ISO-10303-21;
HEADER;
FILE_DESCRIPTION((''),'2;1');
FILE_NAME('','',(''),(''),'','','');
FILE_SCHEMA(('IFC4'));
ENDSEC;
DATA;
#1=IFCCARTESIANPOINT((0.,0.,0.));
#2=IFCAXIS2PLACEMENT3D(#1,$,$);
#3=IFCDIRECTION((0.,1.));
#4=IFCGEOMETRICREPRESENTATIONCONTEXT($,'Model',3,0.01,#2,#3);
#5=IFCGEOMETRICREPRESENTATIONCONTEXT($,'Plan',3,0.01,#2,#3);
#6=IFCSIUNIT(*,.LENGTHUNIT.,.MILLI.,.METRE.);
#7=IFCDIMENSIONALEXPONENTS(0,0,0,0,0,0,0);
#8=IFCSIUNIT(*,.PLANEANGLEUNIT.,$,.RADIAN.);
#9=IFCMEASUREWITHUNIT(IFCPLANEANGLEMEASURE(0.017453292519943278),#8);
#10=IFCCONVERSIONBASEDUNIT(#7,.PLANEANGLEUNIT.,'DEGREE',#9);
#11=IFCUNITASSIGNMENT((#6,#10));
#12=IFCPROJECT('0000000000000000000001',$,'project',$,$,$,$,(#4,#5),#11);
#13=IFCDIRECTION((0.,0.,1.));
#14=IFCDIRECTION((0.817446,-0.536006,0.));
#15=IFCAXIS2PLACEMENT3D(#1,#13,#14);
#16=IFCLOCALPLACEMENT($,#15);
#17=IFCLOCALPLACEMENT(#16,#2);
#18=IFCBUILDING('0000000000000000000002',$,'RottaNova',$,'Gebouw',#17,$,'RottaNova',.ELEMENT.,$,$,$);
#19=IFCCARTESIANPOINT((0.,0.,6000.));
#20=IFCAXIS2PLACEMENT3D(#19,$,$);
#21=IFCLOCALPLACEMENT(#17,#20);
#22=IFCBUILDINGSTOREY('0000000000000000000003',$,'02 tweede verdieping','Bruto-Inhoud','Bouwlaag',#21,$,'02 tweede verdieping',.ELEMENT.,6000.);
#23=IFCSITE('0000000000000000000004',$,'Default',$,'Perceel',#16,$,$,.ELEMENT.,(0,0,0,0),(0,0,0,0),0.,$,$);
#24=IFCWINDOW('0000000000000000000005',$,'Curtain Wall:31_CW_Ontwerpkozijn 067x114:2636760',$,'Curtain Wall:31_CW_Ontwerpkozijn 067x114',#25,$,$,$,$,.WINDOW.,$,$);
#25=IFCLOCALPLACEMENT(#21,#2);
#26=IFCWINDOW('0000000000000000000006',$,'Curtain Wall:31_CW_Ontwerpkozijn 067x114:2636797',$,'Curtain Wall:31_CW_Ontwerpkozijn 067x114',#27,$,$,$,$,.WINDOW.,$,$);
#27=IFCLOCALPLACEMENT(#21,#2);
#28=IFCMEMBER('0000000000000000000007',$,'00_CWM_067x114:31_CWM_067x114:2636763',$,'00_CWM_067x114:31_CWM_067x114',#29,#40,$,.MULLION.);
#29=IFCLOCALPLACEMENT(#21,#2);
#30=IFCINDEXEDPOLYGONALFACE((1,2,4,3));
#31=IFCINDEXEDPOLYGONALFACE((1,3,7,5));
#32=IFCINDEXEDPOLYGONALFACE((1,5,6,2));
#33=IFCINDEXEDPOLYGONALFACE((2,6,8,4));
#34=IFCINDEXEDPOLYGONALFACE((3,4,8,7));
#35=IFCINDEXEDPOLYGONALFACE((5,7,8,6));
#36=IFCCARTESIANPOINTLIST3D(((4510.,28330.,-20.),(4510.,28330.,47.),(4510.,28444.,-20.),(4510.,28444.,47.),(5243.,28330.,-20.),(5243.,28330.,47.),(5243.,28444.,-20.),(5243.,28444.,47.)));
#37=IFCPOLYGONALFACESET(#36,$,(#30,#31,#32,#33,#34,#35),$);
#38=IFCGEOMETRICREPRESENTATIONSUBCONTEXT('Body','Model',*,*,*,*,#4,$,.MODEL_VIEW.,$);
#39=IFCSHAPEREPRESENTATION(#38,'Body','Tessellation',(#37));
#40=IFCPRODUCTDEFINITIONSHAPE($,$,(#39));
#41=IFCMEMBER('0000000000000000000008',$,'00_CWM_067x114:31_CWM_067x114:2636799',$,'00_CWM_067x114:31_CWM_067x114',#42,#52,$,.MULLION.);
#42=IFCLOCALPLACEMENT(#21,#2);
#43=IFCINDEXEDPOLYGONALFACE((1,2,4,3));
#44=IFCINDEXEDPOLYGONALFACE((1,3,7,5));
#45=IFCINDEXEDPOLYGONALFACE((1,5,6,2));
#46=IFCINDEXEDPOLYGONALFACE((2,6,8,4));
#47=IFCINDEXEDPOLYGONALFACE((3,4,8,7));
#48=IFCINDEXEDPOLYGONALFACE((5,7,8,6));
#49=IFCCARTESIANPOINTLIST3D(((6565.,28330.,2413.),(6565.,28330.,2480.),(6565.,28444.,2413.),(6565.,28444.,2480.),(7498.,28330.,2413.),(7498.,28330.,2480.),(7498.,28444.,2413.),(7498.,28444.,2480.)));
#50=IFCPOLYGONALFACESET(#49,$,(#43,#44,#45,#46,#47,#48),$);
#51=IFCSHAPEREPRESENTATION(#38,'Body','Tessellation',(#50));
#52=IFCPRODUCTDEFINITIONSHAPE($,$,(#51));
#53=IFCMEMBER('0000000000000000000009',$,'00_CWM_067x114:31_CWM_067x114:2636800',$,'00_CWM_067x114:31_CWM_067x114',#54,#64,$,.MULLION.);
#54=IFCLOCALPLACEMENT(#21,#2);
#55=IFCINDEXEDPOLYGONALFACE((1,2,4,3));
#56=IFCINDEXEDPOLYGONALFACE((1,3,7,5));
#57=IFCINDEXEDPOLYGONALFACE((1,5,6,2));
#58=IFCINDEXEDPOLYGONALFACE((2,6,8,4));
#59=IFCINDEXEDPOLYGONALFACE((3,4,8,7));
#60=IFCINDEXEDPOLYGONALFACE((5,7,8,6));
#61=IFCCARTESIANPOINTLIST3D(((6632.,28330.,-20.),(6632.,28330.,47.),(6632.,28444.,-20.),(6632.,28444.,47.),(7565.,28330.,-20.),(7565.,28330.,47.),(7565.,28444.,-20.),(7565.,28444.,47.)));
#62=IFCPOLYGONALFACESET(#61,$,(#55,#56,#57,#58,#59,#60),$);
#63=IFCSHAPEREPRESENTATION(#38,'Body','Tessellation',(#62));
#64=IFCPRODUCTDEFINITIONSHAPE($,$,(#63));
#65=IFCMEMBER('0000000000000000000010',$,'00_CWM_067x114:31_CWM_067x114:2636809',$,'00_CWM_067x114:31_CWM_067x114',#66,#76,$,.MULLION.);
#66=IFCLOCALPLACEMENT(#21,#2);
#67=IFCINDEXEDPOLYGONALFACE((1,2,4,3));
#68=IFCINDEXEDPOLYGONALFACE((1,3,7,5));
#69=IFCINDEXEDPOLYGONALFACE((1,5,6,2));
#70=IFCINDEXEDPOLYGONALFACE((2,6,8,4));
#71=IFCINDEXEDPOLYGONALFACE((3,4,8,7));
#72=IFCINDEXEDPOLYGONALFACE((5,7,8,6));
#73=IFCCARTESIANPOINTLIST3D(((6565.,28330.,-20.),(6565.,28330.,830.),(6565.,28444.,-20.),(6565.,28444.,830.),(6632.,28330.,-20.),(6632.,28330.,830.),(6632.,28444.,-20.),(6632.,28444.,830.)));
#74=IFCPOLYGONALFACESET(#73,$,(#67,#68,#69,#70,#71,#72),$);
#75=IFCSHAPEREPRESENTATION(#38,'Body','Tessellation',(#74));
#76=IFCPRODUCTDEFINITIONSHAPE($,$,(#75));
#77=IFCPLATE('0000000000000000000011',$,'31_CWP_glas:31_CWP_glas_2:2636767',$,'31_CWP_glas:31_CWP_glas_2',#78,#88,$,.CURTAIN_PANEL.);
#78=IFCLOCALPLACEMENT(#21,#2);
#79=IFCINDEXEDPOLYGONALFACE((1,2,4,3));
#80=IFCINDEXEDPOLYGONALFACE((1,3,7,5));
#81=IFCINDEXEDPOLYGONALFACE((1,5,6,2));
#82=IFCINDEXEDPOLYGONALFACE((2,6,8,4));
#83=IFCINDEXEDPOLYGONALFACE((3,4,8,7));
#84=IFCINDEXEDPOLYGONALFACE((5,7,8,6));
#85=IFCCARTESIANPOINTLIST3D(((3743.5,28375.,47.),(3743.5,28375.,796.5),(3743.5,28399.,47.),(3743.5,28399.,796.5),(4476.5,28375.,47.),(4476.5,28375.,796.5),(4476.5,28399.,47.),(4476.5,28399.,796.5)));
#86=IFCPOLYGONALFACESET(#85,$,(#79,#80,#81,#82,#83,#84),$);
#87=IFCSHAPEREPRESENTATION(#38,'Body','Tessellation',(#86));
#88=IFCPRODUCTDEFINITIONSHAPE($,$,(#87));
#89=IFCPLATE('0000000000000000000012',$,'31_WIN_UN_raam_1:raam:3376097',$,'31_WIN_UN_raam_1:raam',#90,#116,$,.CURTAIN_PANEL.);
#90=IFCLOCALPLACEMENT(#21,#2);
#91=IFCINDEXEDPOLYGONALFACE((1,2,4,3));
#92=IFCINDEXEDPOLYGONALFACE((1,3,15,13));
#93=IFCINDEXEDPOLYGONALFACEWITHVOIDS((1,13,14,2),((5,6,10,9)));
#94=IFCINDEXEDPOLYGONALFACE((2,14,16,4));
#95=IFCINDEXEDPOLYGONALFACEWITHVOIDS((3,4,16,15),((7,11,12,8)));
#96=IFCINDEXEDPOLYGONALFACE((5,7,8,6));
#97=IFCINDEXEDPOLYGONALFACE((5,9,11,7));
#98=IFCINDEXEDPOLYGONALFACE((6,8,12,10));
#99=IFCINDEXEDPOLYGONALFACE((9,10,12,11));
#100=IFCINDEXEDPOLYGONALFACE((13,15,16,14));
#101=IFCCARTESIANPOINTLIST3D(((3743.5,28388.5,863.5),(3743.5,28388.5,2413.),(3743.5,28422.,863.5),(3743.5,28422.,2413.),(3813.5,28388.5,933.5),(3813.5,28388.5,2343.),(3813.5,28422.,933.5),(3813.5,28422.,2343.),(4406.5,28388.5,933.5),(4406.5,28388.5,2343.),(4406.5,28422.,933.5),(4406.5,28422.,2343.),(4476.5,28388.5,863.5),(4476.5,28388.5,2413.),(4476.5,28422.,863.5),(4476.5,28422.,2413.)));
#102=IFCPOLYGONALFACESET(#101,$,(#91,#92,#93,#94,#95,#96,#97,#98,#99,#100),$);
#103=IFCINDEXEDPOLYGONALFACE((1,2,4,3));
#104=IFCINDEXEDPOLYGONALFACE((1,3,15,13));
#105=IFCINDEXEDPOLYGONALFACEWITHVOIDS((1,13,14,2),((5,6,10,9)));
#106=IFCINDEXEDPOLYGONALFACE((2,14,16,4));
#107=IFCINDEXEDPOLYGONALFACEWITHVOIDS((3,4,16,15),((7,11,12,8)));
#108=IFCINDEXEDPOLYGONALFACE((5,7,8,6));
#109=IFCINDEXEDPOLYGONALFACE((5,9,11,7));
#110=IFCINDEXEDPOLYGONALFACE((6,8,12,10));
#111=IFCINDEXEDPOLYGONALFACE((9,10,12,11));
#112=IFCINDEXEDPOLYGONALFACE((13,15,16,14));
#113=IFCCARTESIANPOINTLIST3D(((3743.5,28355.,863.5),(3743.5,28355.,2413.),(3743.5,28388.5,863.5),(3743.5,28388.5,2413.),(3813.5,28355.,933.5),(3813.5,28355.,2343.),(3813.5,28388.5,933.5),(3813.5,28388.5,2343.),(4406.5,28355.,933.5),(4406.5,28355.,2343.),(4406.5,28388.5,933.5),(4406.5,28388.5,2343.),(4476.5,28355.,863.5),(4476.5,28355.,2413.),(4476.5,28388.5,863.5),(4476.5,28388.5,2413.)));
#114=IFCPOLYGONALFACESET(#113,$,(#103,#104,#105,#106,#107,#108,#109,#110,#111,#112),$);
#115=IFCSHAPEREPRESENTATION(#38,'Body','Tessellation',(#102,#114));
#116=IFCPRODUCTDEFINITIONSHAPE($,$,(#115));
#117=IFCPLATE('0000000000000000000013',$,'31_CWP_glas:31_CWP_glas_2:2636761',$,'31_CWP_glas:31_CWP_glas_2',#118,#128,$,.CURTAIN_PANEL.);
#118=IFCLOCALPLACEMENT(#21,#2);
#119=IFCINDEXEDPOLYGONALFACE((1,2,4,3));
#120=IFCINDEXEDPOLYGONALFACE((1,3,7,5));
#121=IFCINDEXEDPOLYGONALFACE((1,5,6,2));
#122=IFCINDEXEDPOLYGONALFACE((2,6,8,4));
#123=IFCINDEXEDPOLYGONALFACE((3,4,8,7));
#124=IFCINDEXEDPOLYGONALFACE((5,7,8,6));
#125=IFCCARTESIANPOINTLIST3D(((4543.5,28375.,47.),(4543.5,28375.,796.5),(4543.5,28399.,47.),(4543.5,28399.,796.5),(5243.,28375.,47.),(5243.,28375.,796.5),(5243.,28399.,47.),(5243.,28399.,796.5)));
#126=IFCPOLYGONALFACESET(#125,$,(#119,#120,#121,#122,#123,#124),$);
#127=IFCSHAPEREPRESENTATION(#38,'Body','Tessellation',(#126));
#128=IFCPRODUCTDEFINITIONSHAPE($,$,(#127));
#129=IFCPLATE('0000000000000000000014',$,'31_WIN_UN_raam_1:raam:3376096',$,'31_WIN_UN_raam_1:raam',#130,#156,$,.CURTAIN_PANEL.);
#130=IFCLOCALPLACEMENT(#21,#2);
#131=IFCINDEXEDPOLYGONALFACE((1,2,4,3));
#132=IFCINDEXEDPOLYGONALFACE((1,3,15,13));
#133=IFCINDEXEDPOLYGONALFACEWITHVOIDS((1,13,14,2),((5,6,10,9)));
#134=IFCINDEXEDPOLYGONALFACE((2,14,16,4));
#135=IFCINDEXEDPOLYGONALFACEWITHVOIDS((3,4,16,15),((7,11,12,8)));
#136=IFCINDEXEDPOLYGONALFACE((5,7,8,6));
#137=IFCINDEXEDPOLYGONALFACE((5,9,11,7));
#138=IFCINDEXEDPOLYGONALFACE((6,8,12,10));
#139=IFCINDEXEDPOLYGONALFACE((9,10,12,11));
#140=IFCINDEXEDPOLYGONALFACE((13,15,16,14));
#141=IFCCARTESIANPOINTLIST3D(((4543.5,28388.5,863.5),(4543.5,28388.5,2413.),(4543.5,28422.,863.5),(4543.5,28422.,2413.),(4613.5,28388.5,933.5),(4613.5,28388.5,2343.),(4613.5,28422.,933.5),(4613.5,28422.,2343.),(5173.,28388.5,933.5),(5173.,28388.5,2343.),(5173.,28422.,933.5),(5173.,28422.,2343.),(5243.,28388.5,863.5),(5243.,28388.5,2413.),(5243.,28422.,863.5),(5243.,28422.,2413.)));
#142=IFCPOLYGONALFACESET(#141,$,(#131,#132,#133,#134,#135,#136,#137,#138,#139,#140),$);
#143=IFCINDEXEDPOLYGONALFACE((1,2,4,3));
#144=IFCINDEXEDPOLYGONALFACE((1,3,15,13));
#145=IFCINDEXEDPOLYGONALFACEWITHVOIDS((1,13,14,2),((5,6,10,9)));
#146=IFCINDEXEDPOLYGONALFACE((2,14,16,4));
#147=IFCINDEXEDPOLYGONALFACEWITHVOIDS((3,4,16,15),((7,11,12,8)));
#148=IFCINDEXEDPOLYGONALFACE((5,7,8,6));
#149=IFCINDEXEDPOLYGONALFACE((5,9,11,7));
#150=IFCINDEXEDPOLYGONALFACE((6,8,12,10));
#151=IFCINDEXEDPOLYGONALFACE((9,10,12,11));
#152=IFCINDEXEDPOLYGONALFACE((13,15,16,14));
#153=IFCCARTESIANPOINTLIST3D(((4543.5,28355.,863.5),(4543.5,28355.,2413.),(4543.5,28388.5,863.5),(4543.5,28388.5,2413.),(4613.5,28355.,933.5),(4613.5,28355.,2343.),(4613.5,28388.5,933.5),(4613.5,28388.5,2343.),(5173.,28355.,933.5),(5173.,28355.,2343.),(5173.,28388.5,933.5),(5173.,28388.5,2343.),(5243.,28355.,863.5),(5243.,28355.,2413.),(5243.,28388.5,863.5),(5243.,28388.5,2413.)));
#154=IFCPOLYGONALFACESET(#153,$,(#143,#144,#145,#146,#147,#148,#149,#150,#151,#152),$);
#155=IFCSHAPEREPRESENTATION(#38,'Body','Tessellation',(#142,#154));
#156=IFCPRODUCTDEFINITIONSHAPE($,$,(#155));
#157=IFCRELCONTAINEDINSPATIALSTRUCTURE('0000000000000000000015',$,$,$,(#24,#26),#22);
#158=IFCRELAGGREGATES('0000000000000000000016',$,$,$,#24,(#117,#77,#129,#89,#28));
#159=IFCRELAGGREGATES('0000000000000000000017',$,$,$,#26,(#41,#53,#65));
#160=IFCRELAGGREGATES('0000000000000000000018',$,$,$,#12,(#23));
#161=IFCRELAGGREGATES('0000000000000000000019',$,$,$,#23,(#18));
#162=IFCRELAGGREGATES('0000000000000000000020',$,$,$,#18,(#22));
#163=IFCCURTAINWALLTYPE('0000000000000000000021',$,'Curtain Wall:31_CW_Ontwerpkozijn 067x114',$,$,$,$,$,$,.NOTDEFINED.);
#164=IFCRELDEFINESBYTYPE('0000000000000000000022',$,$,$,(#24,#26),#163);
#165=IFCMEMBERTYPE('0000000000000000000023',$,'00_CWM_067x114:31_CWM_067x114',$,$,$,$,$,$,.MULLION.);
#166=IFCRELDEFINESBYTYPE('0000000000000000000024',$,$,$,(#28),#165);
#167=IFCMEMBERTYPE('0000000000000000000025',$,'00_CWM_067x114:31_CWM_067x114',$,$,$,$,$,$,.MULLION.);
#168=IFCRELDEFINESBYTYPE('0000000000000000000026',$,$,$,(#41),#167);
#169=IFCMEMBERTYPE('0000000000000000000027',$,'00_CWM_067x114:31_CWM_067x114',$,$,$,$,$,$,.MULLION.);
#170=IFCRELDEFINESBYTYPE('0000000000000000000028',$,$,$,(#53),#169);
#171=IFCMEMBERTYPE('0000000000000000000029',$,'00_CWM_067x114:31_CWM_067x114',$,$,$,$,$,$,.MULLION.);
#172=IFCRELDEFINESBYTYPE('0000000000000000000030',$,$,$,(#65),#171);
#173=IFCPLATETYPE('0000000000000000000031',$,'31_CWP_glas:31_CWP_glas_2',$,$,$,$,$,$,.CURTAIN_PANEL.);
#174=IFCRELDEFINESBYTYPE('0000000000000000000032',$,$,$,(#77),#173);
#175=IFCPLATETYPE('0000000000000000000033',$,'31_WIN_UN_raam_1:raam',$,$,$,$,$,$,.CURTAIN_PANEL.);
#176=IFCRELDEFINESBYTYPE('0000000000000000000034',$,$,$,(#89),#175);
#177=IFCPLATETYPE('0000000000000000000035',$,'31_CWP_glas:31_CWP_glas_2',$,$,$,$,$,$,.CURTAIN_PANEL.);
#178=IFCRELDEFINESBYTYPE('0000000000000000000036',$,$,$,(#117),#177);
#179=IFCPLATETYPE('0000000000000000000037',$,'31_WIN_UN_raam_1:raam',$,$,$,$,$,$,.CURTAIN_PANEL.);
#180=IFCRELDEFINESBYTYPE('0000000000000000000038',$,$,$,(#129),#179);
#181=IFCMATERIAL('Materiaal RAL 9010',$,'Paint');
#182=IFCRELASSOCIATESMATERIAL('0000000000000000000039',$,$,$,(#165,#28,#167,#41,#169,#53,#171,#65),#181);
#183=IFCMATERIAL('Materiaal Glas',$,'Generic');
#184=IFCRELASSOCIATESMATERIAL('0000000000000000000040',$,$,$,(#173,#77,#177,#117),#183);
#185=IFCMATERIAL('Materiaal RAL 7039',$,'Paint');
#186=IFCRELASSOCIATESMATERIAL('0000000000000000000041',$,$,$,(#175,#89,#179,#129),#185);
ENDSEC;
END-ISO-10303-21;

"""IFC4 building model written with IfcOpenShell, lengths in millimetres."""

from ifc_helpers import new_model, entity, si_unit, converted_unit, direction, frame, origin, place, context, subcontext, project, spatial, indexed_curve, outline, extrude, source, transform, mapped, material, type_object, type_shapes, element, aggregate, save


model = new_model("IFC4")

# Units and contexts
model_context = context("Model", 3, precision=0.01, world=origin(), true_north=direction((0.0, 1.0)))
plan_context = context("Plan", 3, precision=0.01, world=origin(), true_north=direction((0.0, 1.0)))
body_context = subcontext(model_context, "Body", "Model", "MODEL_VIEW")
ifc_project = project(units=[si_unit("LENGTHUNIT", "METRE", prefix="MILLI"), converted_unit("PLANEANGLEUNIT", "DEGREE", entity("IfcPlaneAngleMeasure", 0.017453292519943278), si_unit("PLANEANGLEUNIT", "RADIAN"), dimensions=[0, 0, 0, 0, 0, 0, 0])], contexts=[model_context, plan_context])

# Site, building, storey
site_placement = place(None, frame((0.0, 0.0, 0.0), z_axis=(0.0, 0.0, 1.0), x_axis=(0.817446, -0.536006, 0.0)))
site = spatial("IfcSite", under=ifc_project, at=site_placement, Name="Default", ObjectType="Perceel", CompositionType="ELEMENT", RefLatitude=(0, 0, 0, 0), RefLongitude=(0, 0, 0, 0), RefElevation=0.0)
building_placement = place(site_placement, origin())
building = spatial("IfcBuilding", under=site, at=building_placement, Name="RottaNova", ObjectType="Gebouw", LongName="RottaNova", CompositionType="ELEMENT")
storey_placement = place(building_placement, frame((0.0, 0.0, 6000.0)))
storey = spatial("IfcBuildingStorey", under=building, at=storey_placement, Name="02 tweede verdieping", Description="Bruto-Inhoud", ObjectType="Bouwlaag", LongName="02 tweede verdieping", CompositionType="ELEMENT", Elevation=6000.0)

# Windows
curtain_wall_type = type_object("IfcCurtainWallType", Name="Curtain Wall:31_CW_Ontwerpkozijn 067x114", PredefinedType="NOTDEFINED")
window_1_placement = place(storey_placement, frame((0.0, 0.0, -6000.0)))
window_1 = element("IfcWindow", 1, at=window_1_placement, inside=storey, type_object=curtain_wall_type, Name="Curtain Wall:31_CW_Ontwerpkozijn 067x114:2636760", ObjectType="Curtain Wall:31_CW_Ontwerpkozijn 067x114", PredefinedType="WINDOW")
ifc_material_1 = material(Name="Materiaal RAL 9010", Category="Paint")
window_2_placement = place(storey_placement, frame((0.0, 0.0, -6000.0)))
window_2 = element("IfcWindow", 2, at=window_2_placement, inside=storey, type_object=curtain_wall_type, Name="Curtain Wall:31_CW_Ontwerpkozijn 067x114:2636797", ObjectType="Curtain Wall:31_CW_Ontwerpkozijn 067x114", PredefinedType="WINDOW")

# Members
member_type_1 = type_object("IfcMemberType", Name="00_CWM_067x114:31_CWM_067x114", PredefinedType="MULLION", material=ifc_material_1)
shared_shape_1 = source(origin(), body_context, "Body", "SweptSolid", [
    extrude(outline(indexed_curve([(-33.5, -57.0), (33.5, -57.0), (33.5, 57.0), (-33.5, 57.0), (-33.5, -57.0)], self_intersect=False)), frame((-33.5, 57.0, -733.0), z_axis=(0.0, 0.0, 1.0), x_axis=(-1.0, 0.0, 0.0)), (0.0, 0.0, 1.0), 733.0),
])
type_shapes(member_type_1, [shared_shape_1])
member_1_placement = place(window_1_placement, frame((5243.0, 28330.0, 5980.0), z_axis=(1.0, 0.0, 0.0), x_axis=(0.0, 0.0, -1.0)))
member_1 = element("IfcMember", 3, at=member_1_placement, type_object=member_type_1, material=ifc_material_1, Name="00_CWM_067x114:31_CWM_067x114:2636763", ObjectType="00_CWM_067x114:31_CWM_067x114", PredefinedType="MULLION", context=body_context, shape_type="MappedRepresentation", body=[
    mapped(shared_shape_1, transform((0.0, 0.0, 0.0), scale=1.0)),
])
member_type_2 = type_object("IfcMemberType", Name="00_CWM_067x114:31_CWM_067x114", PredefinedType="MULLION", material=ifc_material_1)
shared_shape_2 = source(origin(), body_context, "Body", "SweptSolid", [
    extrude(outline(indexed_curve([(-33.5, -57.0), (33.5, -57.0), (33.5, 57.0), (-33.5, 57.0), (-33.5, -57.0)], self_intersect=False)), frame((-33.5, -57.0, -933.0), z_axis=(0.0, 0.0, 1.0), x_axis=(-1.0, 0.0, 0.0)), (0.0, 0.0, 1.0), 933.0),
])
type_shapes(member_type_2, [shared_shape_2])
member_2_placement = place(window_2_placement, frame((7498.0, 28330.0, 8480.0), z_axis=(1.0, 0.0, 0.0), x_axis=(0.0, 0.0, 1.0)))
member_2 = element("IfcMember", 4, at=member_2_placement, type_object=member_type_2, material=ifc_material_1, Name="00_CWM_067x114:31_CWM_067x114:2636799", ObjectType="00_CWM_067x114:31_CWM_067x114", PredefinedType="MULLION", context=body_context, shape_type="MappedRepresentation", body=[
    mapped(shared_shape_2, transform((0.0, 0.0, 0.0), scale=1.0)),
])
member_type_3 = type_object("IfcMemberType", Name="00_CWM_067x114:31_CWM_067x114", PredefinedType="MULLION", material=ifc_material_1)
shared_shape_3 = source(origin(), body_context, "Body", "SweptSolid", [
    extrude(outline(indexed_curve([(-33.5, -57.0), (33.5, -57.0), (33.5, 57.0), (-33.5, 57.0), (-33.5, -57.0)], self_intersect=False)), frame((-33.5, -57.0, -933.0), z_axis=(0.0, 0.0, 1.0), x_axis=(-1.0, 0.0, 0.0)), (0.0, 0.0, 1.0), 933.0),
])
type_shapes(member_type_3, [shared_shape_3])
member_3_placement = place(window_2_placement, frame((6632.0, 28330.0, 5980.0), z_axis=(-1.0, 0.0, 0.0), x_axis=(0.0, 0.0, -1.0)))
member_3 = element("IfcMember", 5, at=member_3_placement, type_object=member_type_3, material=ifc_material_1, Name="00_CWM_067x114:31_CWM_067x114:2636800", ObjectType="00_CWM_067x114:31_CWM_067x114", PredefinedType="MULLION", context=body_context, shape_type="MappedRepresentation", body=[
    mapped(shared_shape_3, transform((0.0, 0.0, 0.0), scale=1.0)),
])
member_type_4 = type_object("IfcMemberType", Name="00_CWM_067x114:31_CWM_067x114", PredefinedType="MULLION", material=ifc_material_1)
shared_shape_4 = source(origin(), body_context, "Body", "SweptSolid", [
    extrude(outline(indexed_curve([(-33.5, -57.0), (33.5, -57.0), (33.5, 57.0), (-33.5, 57.0), (-33.5, -57.0)], self_intersect=False)), frame((-33.5, -57.0, -850.0), z_axis=(0.0, 0.0, 1.0), x_axis=(-1.0, 0.0, 0.0)), (0.0, 0.0, 1.0), 850.0),
])
type_shapes(member_type_4, [shared_shape_4])
member_4_placement = place(window_2_placement, frame((6565.0, 28330.0, 6830.0), z_axis=(0.0, 0.0, 1.0), x_axis=(-1.0, 0.0, 0.0)))
member_4 = element("IfcMember", 6, at=member_4_placement, type_object=member_type_4, material=ifc_material_1, Name="00_CWM_067x114:31_CWM_067x114:2636809", ObjectType="00_CWM_067x114:31_CWM_067x114", PredefinedType="MULLION", context=body_context, shape_type="MappedRepresentation", body=[
    mapped(shared_shape_4, transform((0.0, 0.0, 0.0), scale=1.0)),
])

# Plates
ifc_material_2 = material(Name="Materiaal Glas", Category="Generic")
plate_type_1 = type_object("IfcPlateType", Name="31_CWP_glas:31_CWP_glas_2", PredefinedType="CURTAIN_PANEL", material=ifc_material_2)
shared_shape_5 = source(origin(), body_context, "Body", "SweptSolid", [
    extrude(outline(indexed_curve([(-12.0, -366.5), (12.0, -366.5), (12.0, 366.5), (-12.0, 366.5), (-12.0, -366.5)], self_intersect=False)), frame((0.0, -57.0, 0.0), z_axis=(0.0, 0.0, 1.0), x_axis=(0.0, 1.0, 0.0)), (0.0, 0.0, 1.0), 749.5),
])
type_shapes(plate_type_1, [shared_shape_5])
plate_1_placement = place(window_1_placement, frame((4110.0, 28330.0, 6047.0), z_axis=(0.0, 0.0, 1.0), x_axis=(-1.0, 0.0, 0.0)))
plate_1 = element("IfcPlate", 7, at=plate_1_placement, type_object=plate_type_1, material=ifc_material_2, Name="31_CWP_glas:31_CWP_glas_2:2636767", ObjectType="31_CWP_glas:31_CWP_glas_2", PredefinedType="CURTAIN_PANEL", context=body_context, shape_type="MappedRepresentation", body=[
    mapped(shared_shape_5, transform((0.0, 0.0, 0.0), scale=1.0)),
])
ifc_material_3 = material(Name="Materiaal RAL 7039", Category="Paint")
plate_type_2 = type_object("IfcPlateType", Name="31_WIN_UN_raam_1:raam", PredefinedType="CURTAIN_PANEL", material=ifc_material_3)
shared_shape_6 = source(origin(), body_context, "Body", "SweptSolid", [
    extrude(outline(indexed_curve([(-366.5, -774.7), (366.5, -774.7), (366.5, 774.7), (-366.5, 774.7), (-366.5, -774.7)], self_intersect=False), holes=[indexed_curve([(-296.5, 704.7), (296.5, 704.7), (296.5, -704.8), (-296.5, -704.8), (-296.5, 704.7)], self_intersect=False)]), frame((0.0, -92.0, 774.8), z_axis=(0.0, 1.0, 0.0), x_axis=(1.0, 0.0, 0.0)), (0.0, 0.0, 1.0), 33.5),
    extrude(outline(indexed_curve([(-366.5, -774.7), (366.5, -774.7), (366.5, 774.7), (-366.5, 774.7), (-366.5, -774.7)], self_intersect=False), holes=[indexed_curve([(-296.5, 704.7), (296.5, 704.7), (296.5, -704.8), (-296.5, -704.8), (-296.5, 704.7)], self_intersect=False)]), frame((0.0, -58.5, 774.8), z_axis=(0.0, 1.0, 0.0), x_axis=(1.0, 0.0, 0.0)), (0.0, 0.0, 1.0), 33.5),
])
type_shapes(plate_type_2, [shared_shape_6])
plate_2_placement = place(window_1_placement, frame((4110.0, 28330.0, 6863.5), z_axis=(0.0, 0.0, 1.0), x_axis=(-1.0, 0.0, 0.0)))
plate_2 = element("IfcPlate", 8, at=plate_2_placement, type_object=plate_type_2, material=ifc_material_3, Name="31_WIN_UN_raam_1:raam:3376097", ObjectType="31_WIN_UN_raam_1:raam", PredefinedType="CURTAIN_PANEL", context=body_context, shape_type="MappedRepresentation", body=[
    mapped(shared_shape_6, transform((0.0, 0.0, 0.0), scale=1.0)),
])
plate_type_3 = type_object("IfcPlateType", Name="31_CWP_glas:31_CWP_glas_2", PredefinedType="CURTAIN_PANEL", material=ifc_material_2)
shared_shape_7 = source(origin(), body_context, "Body", "SweptSolid", [
    extrude(outline(indexed_curve([(-12.0, -349.7), (12.0, -349.7), (12.0, 349.7), (-12.0, 349.7), (-12.0, -349.7)], self_intersect=False)), frame((0.0, -57.0, 0.0), z_axis=(0.0, 0.0, 1.0), x_axis=(0.0, 1.0, 0.0)), (0.0, 0.0, 1.0), 749.5),
])
type_shapes(plate_type_3, [shared_shape_7])
plate_3_placement = place(window_1_placement, frame((4893.2, 28330.0, 6047.0), z_axis=(0.0, 0.0, 1.0), x_axis=(-1.0, 0.0, 0.0)))
plate_3 = element("IfcPlate", 9, at=plate_3_placement, type_object=plate_type_3, material=ifc_material_2, Name="31_CWP_glas:31_CWP_glas_2:2636761", ObjectType="31_CWP_glas:31_CWP_glas_2", PredefinedType="CURTAIN_PANEL", context=body_context, shape_type="MappedRepresentation", body=[
    mapped(shared_shape_7, transform((0.0, 0.0, 0.0), scale=1.0)),
])
plate_type_4 = type_object("IfcPlateType", Name="31_WIN_UN_raam_1:raam", PredefinedType="CURTAIN_PANEL", material=ifc_material_3)
shared_shape_8 = source(origin(), body_context, "Body", "SweptSolid", [
    extrude(outline(indexed_curve([(-349.7, -774.7), (349.7, -774.7), (349.7, 774.7), (-349.7, 774.7), (-349.7, -774.7)], self_intersect=False), holes=[indexed_curve([(-279.7, 704.7), (279.7, 704.7), (279.7, -704.8), (-279.7, -704.8), (-279.7, 704.7)], self_intersect=False)]), frame((0.0, -92.0, 774.8), z_axis=(0.0, 1.0, 0.0), x_axis=(1.0, 0.0, 0.0)), (0.0, 0.0, 1.0), 33.5),
    extrude(outline(indexed_curve([(-349.7, -774.7), (349.7, -774.7), (349.7, 774.7), (-349.7, 774.7), (-349.7, -774.7)], self_intersect=False), holes=[indexed_curve([(-279.7, 704.7), (279.7, 704.7), (279.7, -704.8), (-279.7, -704.8), (-279.7, 704.7)], self_intersect=False)]), frame((0.0, -58.5, 774.8), z_axis=(0.0, 1.0, 0.0), x_axis=(1.0, 0.0, 0.0)), (0.0, 0.0, 1.0), 33.5),
])
type_shapes(plate_type_4, [shared_shape_8])
plate_4_placement = place(window_1_placement, frame((4893.2, 28330.0, 6863.5), z_axis=(0.0, 0.0, 1.0), x_axis=(-1.0, 0.0, 0.0)))
plate_4 = element("IfcPlate", 10, at=plate_4_placement, type_object=plate_type_4, material=ifc_material_3, Name="31_WIN_UN_raam_1:raam:3376096", ObjectType="31_WIN_UN_raam_1:raam", PredefinedType="CURTAIN_PANEL", context=body_context, shape_type="MappedRepresentation", body=[
    mapped(shared_shape_8, transform((0.0, 0.0, 0.0), scale=1.0)),
])
aggregate(window_1, [plate_3, plate_1, plate_4, plate_2, member_1])
aggregate(window_2, [member_2, member_3, member_4])

save(model, "model.ifc")
